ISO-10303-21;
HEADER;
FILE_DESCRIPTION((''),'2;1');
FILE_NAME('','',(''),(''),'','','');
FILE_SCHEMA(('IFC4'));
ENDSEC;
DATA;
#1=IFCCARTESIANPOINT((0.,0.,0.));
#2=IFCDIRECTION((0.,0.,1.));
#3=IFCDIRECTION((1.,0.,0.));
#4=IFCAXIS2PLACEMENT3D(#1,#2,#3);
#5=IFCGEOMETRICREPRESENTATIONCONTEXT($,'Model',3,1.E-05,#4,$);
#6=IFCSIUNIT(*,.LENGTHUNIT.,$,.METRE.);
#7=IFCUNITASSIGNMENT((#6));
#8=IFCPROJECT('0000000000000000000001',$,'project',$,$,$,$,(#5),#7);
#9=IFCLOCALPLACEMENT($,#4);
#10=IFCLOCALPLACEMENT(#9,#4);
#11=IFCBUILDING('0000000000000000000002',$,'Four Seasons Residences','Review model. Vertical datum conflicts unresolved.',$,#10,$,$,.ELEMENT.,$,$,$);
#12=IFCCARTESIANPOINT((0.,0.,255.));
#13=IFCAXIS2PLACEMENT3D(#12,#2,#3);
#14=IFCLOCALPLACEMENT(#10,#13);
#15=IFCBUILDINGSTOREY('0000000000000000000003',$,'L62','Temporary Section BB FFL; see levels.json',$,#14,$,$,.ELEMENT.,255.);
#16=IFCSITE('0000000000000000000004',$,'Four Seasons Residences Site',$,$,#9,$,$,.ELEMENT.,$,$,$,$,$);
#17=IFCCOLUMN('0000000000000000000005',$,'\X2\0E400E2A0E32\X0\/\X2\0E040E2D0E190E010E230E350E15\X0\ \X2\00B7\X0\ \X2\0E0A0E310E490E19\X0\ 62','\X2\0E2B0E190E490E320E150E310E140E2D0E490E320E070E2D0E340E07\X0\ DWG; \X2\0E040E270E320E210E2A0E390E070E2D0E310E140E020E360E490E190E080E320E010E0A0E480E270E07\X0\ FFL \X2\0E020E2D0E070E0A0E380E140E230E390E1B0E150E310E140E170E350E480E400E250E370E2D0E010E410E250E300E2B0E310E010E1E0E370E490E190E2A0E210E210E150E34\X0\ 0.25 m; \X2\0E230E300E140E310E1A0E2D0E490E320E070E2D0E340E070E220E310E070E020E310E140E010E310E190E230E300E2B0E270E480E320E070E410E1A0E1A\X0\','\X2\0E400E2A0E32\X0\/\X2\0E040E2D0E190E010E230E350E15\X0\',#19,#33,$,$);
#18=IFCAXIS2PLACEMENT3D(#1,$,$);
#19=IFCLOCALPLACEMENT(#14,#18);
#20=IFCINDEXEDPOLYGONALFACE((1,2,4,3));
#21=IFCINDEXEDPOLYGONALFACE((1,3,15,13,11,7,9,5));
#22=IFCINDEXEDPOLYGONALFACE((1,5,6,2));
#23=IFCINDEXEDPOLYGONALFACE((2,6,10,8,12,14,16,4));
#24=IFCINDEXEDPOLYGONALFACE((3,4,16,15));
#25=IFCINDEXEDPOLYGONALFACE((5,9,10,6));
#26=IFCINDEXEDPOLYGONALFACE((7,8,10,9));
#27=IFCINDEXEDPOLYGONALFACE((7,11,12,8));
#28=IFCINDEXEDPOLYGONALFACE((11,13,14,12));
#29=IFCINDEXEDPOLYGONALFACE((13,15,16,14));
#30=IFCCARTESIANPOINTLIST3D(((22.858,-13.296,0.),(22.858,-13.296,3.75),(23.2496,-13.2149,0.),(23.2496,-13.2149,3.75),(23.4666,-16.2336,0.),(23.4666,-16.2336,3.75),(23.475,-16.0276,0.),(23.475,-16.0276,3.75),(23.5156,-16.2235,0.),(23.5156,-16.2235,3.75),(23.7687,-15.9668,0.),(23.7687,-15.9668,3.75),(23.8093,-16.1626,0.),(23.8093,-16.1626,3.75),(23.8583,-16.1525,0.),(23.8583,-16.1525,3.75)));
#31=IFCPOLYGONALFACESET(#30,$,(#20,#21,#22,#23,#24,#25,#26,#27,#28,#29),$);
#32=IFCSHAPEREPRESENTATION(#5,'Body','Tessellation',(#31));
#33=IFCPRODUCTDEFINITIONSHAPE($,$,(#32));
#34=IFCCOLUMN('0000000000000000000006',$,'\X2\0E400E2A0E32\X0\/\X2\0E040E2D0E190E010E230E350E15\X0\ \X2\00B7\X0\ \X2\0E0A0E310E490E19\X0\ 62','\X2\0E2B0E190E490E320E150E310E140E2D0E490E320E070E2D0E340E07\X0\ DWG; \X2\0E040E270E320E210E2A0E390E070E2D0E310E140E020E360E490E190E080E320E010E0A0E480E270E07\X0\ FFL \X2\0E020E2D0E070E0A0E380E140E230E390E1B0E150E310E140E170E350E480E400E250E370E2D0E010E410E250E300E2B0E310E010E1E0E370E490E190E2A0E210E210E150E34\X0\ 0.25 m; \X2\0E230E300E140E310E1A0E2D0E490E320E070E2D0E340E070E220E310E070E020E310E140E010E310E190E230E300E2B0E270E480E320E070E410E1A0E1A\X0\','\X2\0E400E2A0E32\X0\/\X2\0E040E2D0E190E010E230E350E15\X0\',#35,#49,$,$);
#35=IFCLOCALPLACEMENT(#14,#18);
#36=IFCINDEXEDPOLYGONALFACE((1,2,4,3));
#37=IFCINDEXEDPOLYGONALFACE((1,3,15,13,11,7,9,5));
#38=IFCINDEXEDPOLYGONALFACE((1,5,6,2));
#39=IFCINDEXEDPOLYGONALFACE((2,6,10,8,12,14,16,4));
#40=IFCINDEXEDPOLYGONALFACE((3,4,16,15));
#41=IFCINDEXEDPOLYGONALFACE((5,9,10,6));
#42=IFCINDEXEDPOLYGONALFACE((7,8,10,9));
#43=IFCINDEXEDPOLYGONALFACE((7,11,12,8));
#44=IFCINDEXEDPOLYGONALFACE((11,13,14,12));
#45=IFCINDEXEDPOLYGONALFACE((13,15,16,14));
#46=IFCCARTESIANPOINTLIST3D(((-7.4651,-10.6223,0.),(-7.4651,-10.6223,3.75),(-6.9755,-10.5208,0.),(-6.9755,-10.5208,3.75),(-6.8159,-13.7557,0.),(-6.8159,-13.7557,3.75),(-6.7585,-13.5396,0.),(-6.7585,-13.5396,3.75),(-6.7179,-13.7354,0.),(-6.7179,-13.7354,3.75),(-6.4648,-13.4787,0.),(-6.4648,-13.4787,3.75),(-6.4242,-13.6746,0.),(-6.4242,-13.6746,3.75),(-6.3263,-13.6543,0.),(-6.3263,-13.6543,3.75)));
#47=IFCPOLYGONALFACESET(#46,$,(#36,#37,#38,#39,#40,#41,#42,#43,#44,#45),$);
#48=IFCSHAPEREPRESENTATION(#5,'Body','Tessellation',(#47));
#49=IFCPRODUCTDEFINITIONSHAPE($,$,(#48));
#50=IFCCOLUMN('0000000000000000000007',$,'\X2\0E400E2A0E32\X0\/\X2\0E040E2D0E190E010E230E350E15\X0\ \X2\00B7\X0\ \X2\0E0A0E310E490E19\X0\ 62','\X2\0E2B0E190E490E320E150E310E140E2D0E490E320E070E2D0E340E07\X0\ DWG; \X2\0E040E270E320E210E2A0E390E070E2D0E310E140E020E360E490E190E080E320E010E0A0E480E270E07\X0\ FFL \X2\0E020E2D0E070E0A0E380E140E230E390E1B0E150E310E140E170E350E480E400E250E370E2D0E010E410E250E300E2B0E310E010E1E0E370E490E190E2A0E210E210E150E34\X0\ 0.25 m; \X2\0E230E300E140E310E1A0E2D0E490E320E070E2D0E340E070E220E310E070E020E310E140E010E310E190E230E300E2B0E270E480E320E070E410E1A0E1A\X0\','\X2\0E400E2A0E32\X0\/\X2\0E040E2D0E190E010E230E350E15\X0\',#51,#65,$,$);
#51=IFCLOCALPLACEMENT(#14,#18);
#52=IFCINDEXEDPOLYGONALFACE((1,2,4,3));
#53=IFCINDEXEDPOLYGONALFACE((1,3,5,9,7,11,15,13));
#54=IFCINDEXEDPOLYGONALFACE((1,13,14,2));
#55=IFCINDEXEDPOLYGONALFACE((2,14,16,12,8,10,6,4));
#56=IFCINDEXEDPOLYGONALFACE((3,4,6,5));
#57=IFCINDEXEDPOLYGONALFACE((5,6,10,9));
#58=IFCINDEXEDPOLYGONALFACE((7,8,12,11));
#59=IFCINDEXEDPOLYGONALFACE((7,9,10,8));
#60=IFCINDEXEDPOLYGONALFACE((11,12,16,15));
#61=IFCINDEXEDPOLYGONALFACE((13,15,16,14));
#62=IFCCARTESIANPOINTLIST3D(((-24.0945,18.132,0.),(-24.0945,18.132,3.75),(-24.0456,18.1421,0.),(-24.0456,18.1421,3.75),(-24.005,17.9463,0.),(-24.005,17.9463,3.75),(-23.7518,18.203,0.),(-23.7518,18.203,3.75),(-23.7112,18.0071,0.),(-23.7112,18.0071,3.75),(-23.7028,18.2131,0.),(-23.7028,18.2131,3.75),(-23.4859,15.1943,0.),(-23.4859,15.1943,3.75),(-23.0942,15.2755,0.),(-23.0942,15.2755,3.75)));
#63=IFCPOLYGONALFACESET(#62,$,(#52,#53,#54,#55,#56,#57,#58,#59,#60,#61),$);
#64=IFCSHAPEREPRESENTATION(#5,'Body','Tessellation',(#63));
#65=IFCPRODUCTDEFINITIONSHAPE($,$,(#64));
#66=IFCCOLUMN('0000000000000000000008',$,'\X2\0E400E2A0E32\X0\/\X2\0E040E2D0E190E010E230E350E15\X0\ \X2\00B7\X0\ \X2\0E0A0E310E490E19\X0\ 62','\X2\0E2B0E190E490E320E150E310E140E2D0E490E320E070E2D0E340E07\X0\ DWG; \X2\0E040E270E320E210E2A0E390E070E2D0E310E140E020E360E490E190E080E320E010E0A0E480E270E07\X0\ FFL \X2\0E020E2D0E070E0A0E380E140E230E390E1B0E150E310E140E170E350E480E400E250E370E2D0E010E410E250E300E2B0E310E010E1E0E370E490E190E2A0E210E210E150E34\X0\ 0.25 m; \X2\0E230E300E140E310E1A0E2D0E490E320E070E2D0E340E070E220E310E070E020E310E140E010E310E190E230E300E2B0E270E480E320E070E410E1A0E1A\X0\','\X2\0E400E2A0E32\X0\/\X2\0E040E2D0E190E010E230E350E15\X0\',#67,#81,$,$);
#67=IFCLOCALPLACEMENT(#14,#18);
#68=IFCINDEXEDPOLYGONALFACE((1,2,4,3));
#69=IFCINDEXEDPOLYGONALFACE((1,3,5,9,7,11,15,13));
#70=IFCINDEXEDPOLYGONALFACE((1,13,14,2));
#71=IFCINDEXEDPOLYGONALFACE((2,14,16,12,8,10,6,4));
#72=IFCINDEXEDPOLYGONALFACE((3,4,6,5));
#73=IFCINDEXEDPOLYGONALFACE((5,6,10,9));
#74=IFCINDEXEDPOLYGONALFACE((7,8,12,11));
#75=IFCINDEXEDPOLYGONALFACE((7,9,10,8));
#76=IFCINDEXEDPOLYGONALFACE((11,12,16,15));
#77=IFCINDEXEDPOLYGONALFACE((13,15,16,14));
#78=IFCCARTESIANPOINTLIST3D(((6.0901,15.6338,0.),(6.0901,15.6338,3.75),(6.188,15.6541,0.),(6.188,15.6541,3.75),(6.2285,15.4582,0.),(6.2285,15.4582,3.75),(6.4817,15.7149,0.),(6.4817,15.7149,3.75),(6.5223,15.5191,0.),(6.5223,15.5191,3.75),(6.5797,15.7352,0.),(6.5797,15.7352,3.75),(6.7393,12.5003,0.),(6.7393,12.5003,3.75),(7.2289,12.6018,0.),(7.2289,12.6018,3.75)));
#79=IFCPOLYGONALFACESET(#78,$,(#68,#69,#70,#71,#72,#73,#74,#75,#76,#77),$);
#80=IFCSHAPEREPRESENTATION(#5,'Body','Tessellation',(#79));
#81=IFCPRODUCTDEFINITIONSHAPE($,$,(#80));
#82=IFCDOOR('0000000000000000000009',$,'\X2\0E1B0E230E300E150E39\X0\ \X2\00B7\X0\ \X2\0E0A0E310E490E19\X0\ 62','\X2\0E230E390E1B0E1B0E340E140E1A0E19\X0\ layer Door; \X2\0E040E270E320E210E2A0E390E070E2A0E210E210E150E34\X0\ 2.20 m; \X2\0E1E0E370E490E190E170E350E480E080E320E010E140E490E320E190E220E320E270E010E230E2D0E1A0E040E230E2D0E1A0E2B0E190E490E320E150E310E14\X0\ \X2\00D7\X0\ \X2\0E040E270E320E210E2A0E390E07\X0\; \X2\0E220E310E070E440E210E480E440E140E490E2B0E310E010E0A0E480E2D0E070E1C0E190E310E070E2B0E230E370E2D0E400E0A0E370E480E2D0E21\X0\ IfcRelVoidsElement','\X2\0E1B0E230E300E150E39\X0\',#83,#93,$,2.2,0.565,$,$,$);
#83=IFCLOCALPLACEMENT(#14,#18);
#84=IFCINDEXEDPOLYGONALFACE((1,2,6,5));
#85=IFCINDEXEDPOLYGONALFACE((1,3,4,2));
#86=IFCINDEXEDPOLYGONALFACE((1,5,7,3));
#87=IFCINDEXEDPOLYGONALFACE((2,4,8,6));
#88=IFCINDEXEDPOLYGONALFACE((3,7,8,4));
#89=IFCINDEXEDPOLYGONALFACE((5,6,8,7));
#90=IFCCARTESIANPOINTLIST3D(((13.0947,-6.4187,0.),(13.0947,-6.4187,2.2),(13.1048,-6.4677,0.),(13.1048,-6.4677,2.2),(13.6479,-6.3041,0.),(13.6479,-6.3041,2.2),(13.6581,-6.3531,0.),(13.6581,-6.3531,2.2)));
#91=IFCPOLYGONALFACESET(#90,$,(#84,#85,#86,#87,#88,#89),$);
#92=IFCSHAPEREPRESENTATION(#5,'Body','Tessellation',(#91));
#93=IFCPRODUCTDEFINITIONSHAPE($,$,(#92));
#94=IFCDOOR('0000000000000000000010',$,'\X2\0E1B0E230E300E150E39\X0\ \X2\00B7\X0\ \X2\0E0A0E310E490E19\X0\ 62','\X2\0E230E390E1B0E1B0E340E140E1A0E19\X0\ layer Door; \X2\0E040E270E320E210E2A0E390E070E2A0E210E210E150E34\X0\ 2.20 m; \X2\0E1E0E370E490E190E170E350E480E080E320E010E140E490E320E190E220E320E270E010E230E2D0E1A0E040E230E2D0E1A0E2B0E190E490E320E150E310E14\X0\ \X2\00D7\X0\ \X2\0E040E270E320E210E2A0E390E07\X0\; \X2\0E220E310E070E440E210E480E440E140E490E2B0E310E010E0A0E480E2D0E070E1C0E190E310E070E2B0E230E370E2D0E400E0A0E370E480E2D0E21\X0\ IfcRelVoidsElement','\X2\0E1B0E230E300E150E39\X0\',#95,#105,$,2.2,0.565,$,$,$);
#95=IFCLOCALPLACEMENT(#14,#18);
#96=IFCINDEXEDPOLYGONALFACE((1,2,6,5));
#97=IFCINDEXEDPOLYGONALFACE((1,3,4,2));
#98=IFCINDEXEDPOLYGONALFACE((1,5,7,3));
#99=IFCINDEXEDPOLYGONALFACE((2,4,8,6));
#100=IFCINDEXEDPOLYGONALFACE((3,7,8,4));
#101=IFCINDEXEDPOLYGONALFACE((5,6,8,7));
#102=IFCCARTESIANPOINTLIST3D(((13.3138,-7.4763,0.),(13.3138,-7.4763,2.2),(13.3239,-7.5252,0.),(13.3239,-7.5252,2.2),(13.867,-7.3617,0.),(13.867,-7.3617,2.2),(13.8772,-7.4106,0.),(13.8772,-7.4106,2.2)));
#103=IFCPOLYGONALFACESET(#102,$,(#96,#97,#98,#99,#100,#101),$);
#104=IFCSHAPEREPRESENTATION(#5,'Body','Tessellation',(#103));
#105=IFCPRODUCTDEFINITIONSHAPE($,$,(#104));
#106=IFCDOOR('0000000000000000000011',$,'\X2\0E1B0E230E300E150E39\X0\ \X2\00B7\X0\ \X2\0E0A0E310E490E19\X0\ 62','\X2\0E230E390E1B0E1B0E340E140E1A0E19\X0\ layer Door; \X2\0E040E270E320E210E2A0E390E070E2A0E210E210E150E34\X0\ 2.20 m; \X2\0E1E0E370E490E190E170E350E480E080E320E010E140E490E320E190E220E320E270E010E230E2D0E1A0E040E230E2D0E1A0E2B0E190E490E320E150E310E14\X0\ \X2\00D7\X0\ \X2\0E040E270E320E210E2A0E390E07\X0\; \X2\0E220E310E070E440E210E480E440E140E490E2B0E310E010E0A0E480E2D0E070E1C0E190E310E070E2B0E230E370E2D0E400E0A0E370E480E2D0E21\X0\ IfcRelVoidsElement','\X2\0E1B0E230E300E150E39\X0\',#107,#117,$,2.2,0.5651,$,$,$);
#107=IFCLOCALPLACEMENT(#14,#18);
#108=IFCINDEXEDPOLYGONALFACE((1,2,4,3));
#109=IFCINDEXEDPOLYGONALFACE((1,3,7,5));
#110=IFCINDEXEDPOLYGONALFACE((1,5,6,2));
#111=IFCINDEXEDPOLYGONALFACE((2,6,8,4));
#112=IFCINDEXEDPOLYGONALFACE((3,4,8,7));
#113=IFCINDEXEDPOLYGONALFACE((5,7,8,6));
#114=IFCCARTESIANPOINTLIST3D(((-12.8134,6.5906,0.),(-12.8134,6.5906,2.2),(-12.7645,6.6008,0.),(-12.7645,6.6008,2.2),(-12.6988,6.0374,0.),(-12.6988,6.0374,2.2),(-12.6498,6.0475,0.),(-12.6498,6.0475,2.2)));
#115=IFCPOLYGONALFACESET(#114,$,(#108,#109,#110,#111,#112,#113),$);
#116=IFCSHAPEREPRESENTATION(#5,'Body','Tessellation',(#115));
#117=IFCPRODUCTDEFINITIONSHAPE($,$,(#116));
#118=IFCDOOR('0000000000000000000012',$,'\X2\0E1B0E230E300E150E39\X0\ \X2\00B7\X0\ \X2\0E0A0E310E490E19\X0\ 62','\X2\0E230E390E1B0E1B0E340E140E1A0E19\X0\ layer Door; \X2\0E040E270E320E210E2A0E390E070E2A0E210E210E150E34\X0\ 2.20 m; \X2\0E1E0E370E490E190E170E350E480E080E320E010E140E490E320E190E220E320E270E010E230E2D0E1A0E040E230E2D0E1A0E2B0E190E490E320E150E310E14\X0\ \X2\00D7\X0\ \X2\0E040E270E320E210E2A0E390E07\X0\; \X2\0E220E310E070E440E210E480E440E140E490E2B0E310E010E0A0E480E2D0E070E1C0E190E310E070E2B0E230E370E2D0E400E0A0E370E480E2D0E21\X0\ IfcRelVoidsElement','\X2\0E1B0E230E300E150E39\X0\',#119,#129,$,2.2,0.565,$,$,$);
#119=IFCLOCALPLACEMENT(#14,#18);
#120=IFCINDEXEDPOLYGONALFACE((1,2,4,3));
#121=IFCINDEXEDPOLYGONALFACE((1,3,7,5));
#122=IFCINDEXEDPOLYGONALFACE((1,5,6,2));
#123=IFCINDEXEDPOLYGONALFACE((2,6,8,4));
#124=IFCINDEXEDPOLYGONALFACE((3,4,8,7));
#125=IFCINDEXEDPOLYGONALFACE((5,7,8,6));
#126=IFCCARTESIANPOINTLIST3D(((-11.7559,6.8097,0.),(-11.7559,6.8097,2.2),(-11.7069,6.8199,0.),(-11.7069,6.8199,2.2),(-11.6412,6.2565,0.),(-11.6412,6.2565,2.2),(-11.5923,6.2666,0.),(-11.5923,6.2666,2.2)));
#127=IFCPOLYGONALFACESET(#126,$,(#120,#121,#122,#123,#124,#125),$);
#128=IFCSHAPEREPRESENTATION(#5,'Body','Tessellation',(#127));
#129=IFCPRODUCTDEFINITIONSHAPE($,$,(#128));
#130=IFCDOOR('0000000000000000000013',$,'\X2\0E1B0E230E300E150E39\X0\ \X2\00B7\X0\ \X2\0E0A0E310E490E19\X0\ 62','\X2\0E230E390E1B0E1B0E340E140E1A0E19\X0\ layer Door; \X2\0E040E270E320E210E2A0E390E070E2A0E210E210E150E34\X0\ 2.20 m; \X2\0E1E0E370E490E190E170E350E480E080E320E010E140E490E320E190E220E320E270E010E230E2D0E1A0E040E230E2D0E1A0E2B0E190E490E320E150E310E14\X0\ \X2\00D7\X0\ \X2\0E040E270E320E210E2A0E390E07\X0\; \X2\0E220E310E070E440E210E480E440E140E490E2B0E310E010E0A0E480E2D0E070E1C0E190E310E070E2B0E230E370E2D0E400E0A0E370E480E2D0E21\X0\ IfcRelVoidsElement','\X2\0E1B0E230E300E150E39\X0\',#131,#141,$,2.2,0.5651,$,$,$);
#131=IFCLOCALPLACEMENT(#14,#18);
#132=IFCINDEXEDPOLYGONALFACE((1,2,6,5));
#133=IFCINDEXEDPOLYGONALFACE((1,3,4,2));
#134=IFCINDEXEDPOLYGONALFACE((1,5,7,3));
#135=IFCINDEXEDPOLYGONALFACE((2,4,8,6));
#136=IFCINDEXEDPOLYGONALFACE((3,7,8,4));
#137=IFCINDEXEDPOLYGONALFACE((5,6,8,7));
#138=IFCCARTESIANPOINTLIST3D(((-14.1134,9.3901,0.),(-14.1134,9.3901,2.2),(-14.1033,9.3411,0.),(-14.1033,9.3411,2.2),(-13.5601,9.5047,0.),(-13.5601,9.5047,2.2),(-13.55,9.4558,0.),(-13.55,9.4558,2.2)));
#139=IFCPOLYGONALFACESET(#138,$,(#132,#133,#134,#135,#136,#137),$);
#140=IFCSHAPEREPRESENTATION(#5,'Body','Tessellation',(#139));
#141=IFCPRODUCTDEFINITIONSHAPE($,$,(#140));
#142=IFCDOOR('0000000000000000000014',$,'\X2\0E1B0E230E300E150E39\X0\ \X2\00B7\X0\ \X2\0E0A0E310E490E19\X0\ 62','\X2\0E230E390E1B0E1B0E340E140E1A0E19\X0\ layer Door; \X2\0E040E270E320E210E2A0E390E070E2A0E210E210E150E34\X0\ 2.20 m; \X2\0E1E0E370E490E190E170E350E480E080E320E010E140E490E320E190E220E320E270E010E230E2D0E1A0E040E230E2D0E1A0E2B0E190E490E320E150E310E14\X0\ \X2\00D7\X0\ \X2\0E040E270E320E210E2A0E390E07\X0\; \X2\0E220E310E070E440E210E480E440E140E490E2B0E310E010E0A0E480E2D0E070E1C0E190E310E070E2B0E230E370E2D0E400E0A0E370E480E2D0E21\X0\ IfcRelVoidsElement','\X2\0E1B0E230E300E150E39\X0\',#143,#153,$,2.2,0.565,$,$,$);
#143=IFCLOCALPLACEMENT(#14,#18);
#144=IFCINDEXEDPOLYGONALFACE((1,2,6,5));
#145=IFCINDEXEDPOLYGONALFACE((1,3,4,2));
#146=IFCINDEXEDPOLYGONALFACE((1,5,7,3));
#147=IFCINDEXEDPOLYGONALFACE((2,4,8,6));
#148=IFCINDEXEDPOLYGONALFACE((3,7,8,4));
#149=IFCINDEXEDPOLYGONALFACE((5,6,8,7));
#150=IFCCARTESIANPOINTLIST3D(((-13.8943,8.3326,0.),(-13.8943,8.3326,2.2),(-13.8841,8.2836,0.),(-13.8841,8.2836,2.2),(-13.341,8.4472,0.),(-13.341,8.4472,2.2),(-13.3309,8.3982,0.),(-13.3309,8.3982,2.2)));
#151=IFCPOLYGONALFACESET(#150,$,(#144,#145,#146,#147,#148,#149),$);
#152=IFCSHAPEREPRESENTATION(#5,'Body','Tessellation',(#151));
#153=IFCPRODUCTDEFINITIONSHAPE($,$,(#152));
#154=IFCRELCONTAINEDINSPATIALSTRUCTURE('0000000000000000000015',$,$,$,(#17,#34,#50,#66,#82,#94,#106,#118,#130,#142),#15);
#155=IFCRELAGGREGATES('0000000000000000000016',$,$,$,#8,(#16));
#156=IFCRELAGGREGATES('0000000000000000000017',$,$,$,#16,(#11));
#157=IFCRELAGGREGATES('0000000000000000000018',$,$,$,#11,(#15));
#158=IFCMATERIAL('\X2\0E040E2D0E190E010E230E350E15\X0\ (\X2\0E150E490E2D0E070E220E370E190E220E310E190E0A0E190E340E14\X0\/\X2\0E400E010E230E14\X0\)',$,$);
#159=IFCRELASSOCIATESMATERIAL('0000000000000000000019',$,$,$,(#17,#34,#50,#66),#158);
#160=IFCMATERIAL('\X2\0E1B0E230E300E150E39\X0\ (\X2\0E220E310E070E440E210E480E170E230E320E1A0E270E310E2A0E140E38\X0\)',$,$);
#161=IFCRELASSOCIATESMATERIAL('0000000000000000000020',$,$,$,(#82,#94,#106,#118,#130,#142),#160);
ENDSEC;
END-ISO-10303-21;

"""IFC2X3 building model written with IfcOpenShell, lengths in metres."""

from ifc_helpers import new_model, si_unit, frame, origin_with_axes, place, context, project, spatial, polyline, outline, extrude, material, element, save


model = new_model("IFC2X3")

# Units and contexts
model_context = context("Model", 3, precision=1e-05, world=origin_with_axes())
ifc_project = project(units=[si_unit("LENGTHUNIT", "METRE")], contexts=[model_context])

# Site, building, storey
site_placement = place(None, origin_with_axes())
site = spatial("IfcSite", under=ifc_project, at=site_placement, Name="Four Seasons Residences Site", CompositionType="ELEMENT")
building_placement = place(site_placement, origin_with_axes())
building = spatial("IfcBuilding", under=site, at=building_placement, Name="Four Seasons Residences", Description="Review model. Vertical datum conflicts unresolved.", CompositionType="ELEMENT")
storey_placement = place(building_placement, frame((0.0, 0.0, 255.0), z_axis=(0.0, 0.0, 1.0), x_axis=(1.0, 0.0, 0.0)))
storey = spatial("IfcBuildingStorey", under=building, at=storey_placement, Name="L62", Description="Temporary Section BB FFL; see levels.json", CompositionType="ELEMENT", Elevation=255.0)

# Columns
ifc_material_1 = material(Name="คอนกรีต (ต้องยืนยันชนิด/เกรด)")
column_1_placement = place(storey_placement, origin_with_axes())
element("IfcColumn", 1, at=column_1_placement, inside=storey, material=ifc_material_1, Name="เสา/คอนกรีต · ชั้น 62", Description="หน้าตัดอ้างอิง DWG; ความสูงอัดขึ้นจากช่วง FFL ของชุดรูปตัดที่เลือกและหักพื้นสมมติ 0.25 m; ระดับอ้างอิงยังขัดกันระหว่างแบบ", ObjectType="เสา/คอนกรีต", context=model_context, shape_type="SweptSolid", body=[
    extrude(outline(polyline([(23.2496, -13.2149), (22.858, -13.296), (23.4666, -16.2336), (23.5156, -16.2235), (23.475, -16.0276), (23.7687, -15.9668), (23.8093, -16.1626), (23.8583, -16.1525), (23.2496, -13.2149)])), origin_with_axes(), (0.0, 0.0, 1.0), 3.75),
])
column_2_placement = place(storey_placement, origin_with_axes())
element("IfcColumn", 2, at=column_2_placement, inside=storey, material=ifc_material_1, Name="เสา/คอนกรีต · ชั้น 62", Description="หน้าตัดอ้างอิง DWG; ความสูงอัดขึ้นจากช่วง FFL ของชุดรูปตัดที่เลือกและหักพื้นสมมติ 0.25 m; ระดับอ้างอิงยังขัดกันระหว่างแบบ", ObjectType="เสา/คอนกรีต", context=model_context, shape_type="SweptSolid", body=[
    extrude(outline(polyline([(-6.9755, -10.5208), (-7.4651, -10.6223), (-6.8159, -13.7557), (-6.7179, -13.7354), (-6.7585, -13.5396), (-6.4648, -13.4787), (-6.4242, -13.6746), (-6.3263, -13.6543), (-6.9755, -10.5208)])), origin_with_axes(), (0.0, 0.0, 1.0), 3.75),
])
column_3_placement = place(storey_placement, origin_with_axes())
element("IfcColumn", 3, at=column_3_placement, inside=storey, material=ifc_material_1, Name="เสา/คอนกรีต · ชั้น 62", Description="หน้าตัดอ้างอิง DWG; ความสูงอัดขึ้นจากช่วง FFL ของชุดรูปตัดที่เลือกและหักพื้นสมมติ 0.25 m; ระดับอ้างอิงยังขัดกันระหว่างแบบ", ObjectType="เสา/คอนกรีต", context=model_context, shape_type="SweptSolid", body=[
    extrude(outline(polyline([(-23.7028, 18.2131), (-23.7518, 18.203), (-23.7112, 18.0071), (-24.005, 17.9463), (-24.0456, 18.1421), (-24.0945, 18.132), (-23.4859, 15.1943), (-23.0942, 15.2755), (-23.7028, 18.2131)])), origin_with_axes(), (0.0, 0.0, 1.0), 3.75),
])
column_4_placement = place(storey_placement, origin_with_axes())
element("IfcColumn", 4, at=column_4_placement, inside=storey, material=ifc_material_1, Name="เสา/คอนกรีต · ชั้น 62", Description="หน้าตัดอ้างอิง DWG; ความสูงอัดขึ้นจากช่วง FFL ของชุดรูปตัดที่เลือกและหักพื้นสมมติ 0.25 m; ระดับอ้างอิงยังขัดกันระหว่างแบบ", ObjectType="เสา/คอนกรีต", context=model_context, shape_type="SweptSolid", body=[
    extrude(outline(polyline([(6.5797, 15.7352), (6.4817, 15.7149), (6.5223, 15.5191), (6.2285, 15.4582), (6.188, 15.6541), (6.0901, 15.6338), (6.7393, 12.5003), (7.2289, 12.6018), (6.5797, 15.7352)])), origin_with_axes(), (0.0, 0.0, 1.0), 3.75),
])

# Doors
ifc_material_2 = material(Name="ประตู (ยังไม่ทราบวัสดุ)")
door_1_placement = place(storey_placement, origin_with_axes())
element("IfcDoor", 5, at=door_1_placement, inside=storey, material=ifc_material_2, Name="ประตู · ชั้น 62", Description="รูปปิดบน layer Door; ความสูงสมมติ 2.20 m; พื้นที่จากด้านยาวกรอบครอบหน้าตัด × ความสูง; ยังไม่ได้หักช่องผนังหรือเชื่อม IfcRelVoidsElement", ObjectType="ประตู", OverallHeight=2.2, OverallWidth=0.565, context=model_context, shape_type="SweptSolid", body=[
    extrude(outline(polyline([(13.0947, -6.4187), (13.6479, -6.3041), (13.6581, -6.3531), (13.1048, -6.4677), (13.0947, -6.4187)])), origin_with_axes(), (0.0, 0.0, 1.0), 2.2),
])
door_2_placement = place(storey_placement, origin_with_axes())
element("IfcDoor", 6, at=door_2_placement, inside=storey, material=ifc_material_2, Name="ประตู · ชั้น 62", Description="รูปปิดบน layer Door; ความสูงสมมติ 2.20 m; พื้นที่จากด้านยาวกรอบครอบหน้าตัด × ความสูง; ยังไม่ได้หักช่องผนังหรือเชื่อม IfcRelVoidsElement", ObjectType="ประตู", OverallHeight=2.2, OverallWidth=0.565, context=model_context, shape_type="SweptSolid", body=[
    extrude(outline(polyline([(13.3239, -7.5252), (13.8772, -7.4106), (13.867, -7.3617), (13.3138, -7.4763), (13.3239, -7.5252)])), origin_with_axes(), (0.0, 0.0, 1.0), 2.2),
])
door_3_placement = place(storey_placement, origin_with_axes())
element("IfcDoor", 7, at=door_3_placement, inside=storey, material=ifc_material_2, Name="ประตู · ชั้น 62", Description="รูปปิดบน layer Door; ความสูงสมมติ 2.20 m; พื้นที่จากด้านยาวกรอบครอบหน้าตัด × ความสูง; ยังไม่ได้หักช่องผนังหรือเชื่อม IfcRelVoidsElement", ObjectType="ประตู", OverallHeight=2.2, OverallWidth=0.5651, context=model_context, shape_type="SweptSolid", body=[
    extrude(outline(polyline([(-12.6988, 6.0374), (-12.8134, 6.5906), (-12.7645, 6.6008), (-12.6498, 6.0475), (-12.6988, 6.0374)])), origin_with_axes(), (0.0, 0.0, 1.0), 2.2),
])
door_4_placement = place(storey_placement, origin_with_axes())
element("IfcDoor", 8, at=door_4_placement, inside=storey, material=ifc_material_2, Name="ประตู · ชั้น 62", Description="รูปปิดบน layer Door; ความสูงสมมติ 2.20 m; พื้นที่จากด้านยาวกรอบครอบหน้าตัด × ความสูง; ยังไม่ได้หักช่องผนังหรือเชื่อม IfcRelVoidsElement", ObjectType="ประตู", OverallHeight=2.2, OverallWidth=0.565, context=model_context, shape_type="SweptSolid", body=[
    extrude(outline(polyline([(-11.5923, 6.2666), (-11.7069, 6.8199), (-11.7559, 6.8097), (-11.6412, 6.2565), (-11.5923, 6.2666)])), origin_with_axes(), (0.0, 0.0, 1.0), 2.2),
])
door_5_placement = place(storey_placement, origin_with_axes())
element("IfcDoor", 9, at=door_5_placement, inside=storey, material=ifc_material_2, Name="ประตู · ชั้น 62", Description="รูปปิดบน layer Door; ความสูงสมมติ 2.20 m; พื้นที่จากด้านยาวกรอบครอบหน้าตัด × ความสูง; ยังไม่ได้หักช่องผนังหรือเชื่อม IfcRelVoidsElement", ObjectType="ประตู", OverallHeight=2.2, OverallWidth=0.5651, context=model_context, shape_type="SweptSolid", body=[
    extrude(outline(polyline([(-13.5601, 9.5047), (-14.1134, 9.3901), (-14.1033, 9.3411), (-13.55, 9.4558), (-13.5601, 9.5047)])), origin_with_axes(), (0.0, 0.0, 1.0), 2.2),
])
door_6_placement = place(storey_placement, origin_with_axes())
element("IfcDoor", 10, at=door_6_placement, inside=storey, material=ifc_material_2, Name="ประตู · ชั้น 62", Description="รูปปิดบน layer Door; ความสูงสมมติ 2.20 m; พื้นที่จากด้านยาวกรอบครอบหน้าตัด × ความสูง; ยังไม่ได้หักช่องผนังหรือเชื่อม IfcRelVoidsElement", ObjectType="ประตู", OverallHeight=2.2, OverallWidth=0.565, context=model_context, shape_type="SweptSolid", body=[
    extrude(outline(polyline([(-13.3309, 8.3982), (-13.8841, 8.2836), (-13.8943, 8.3326), (-13.341, 8.4472), (-13.3309, 8.3982)])), origin_with_axes(), (0.0, 0.0, 1.0), 2.2),
])

save(model, "model.ifc")
